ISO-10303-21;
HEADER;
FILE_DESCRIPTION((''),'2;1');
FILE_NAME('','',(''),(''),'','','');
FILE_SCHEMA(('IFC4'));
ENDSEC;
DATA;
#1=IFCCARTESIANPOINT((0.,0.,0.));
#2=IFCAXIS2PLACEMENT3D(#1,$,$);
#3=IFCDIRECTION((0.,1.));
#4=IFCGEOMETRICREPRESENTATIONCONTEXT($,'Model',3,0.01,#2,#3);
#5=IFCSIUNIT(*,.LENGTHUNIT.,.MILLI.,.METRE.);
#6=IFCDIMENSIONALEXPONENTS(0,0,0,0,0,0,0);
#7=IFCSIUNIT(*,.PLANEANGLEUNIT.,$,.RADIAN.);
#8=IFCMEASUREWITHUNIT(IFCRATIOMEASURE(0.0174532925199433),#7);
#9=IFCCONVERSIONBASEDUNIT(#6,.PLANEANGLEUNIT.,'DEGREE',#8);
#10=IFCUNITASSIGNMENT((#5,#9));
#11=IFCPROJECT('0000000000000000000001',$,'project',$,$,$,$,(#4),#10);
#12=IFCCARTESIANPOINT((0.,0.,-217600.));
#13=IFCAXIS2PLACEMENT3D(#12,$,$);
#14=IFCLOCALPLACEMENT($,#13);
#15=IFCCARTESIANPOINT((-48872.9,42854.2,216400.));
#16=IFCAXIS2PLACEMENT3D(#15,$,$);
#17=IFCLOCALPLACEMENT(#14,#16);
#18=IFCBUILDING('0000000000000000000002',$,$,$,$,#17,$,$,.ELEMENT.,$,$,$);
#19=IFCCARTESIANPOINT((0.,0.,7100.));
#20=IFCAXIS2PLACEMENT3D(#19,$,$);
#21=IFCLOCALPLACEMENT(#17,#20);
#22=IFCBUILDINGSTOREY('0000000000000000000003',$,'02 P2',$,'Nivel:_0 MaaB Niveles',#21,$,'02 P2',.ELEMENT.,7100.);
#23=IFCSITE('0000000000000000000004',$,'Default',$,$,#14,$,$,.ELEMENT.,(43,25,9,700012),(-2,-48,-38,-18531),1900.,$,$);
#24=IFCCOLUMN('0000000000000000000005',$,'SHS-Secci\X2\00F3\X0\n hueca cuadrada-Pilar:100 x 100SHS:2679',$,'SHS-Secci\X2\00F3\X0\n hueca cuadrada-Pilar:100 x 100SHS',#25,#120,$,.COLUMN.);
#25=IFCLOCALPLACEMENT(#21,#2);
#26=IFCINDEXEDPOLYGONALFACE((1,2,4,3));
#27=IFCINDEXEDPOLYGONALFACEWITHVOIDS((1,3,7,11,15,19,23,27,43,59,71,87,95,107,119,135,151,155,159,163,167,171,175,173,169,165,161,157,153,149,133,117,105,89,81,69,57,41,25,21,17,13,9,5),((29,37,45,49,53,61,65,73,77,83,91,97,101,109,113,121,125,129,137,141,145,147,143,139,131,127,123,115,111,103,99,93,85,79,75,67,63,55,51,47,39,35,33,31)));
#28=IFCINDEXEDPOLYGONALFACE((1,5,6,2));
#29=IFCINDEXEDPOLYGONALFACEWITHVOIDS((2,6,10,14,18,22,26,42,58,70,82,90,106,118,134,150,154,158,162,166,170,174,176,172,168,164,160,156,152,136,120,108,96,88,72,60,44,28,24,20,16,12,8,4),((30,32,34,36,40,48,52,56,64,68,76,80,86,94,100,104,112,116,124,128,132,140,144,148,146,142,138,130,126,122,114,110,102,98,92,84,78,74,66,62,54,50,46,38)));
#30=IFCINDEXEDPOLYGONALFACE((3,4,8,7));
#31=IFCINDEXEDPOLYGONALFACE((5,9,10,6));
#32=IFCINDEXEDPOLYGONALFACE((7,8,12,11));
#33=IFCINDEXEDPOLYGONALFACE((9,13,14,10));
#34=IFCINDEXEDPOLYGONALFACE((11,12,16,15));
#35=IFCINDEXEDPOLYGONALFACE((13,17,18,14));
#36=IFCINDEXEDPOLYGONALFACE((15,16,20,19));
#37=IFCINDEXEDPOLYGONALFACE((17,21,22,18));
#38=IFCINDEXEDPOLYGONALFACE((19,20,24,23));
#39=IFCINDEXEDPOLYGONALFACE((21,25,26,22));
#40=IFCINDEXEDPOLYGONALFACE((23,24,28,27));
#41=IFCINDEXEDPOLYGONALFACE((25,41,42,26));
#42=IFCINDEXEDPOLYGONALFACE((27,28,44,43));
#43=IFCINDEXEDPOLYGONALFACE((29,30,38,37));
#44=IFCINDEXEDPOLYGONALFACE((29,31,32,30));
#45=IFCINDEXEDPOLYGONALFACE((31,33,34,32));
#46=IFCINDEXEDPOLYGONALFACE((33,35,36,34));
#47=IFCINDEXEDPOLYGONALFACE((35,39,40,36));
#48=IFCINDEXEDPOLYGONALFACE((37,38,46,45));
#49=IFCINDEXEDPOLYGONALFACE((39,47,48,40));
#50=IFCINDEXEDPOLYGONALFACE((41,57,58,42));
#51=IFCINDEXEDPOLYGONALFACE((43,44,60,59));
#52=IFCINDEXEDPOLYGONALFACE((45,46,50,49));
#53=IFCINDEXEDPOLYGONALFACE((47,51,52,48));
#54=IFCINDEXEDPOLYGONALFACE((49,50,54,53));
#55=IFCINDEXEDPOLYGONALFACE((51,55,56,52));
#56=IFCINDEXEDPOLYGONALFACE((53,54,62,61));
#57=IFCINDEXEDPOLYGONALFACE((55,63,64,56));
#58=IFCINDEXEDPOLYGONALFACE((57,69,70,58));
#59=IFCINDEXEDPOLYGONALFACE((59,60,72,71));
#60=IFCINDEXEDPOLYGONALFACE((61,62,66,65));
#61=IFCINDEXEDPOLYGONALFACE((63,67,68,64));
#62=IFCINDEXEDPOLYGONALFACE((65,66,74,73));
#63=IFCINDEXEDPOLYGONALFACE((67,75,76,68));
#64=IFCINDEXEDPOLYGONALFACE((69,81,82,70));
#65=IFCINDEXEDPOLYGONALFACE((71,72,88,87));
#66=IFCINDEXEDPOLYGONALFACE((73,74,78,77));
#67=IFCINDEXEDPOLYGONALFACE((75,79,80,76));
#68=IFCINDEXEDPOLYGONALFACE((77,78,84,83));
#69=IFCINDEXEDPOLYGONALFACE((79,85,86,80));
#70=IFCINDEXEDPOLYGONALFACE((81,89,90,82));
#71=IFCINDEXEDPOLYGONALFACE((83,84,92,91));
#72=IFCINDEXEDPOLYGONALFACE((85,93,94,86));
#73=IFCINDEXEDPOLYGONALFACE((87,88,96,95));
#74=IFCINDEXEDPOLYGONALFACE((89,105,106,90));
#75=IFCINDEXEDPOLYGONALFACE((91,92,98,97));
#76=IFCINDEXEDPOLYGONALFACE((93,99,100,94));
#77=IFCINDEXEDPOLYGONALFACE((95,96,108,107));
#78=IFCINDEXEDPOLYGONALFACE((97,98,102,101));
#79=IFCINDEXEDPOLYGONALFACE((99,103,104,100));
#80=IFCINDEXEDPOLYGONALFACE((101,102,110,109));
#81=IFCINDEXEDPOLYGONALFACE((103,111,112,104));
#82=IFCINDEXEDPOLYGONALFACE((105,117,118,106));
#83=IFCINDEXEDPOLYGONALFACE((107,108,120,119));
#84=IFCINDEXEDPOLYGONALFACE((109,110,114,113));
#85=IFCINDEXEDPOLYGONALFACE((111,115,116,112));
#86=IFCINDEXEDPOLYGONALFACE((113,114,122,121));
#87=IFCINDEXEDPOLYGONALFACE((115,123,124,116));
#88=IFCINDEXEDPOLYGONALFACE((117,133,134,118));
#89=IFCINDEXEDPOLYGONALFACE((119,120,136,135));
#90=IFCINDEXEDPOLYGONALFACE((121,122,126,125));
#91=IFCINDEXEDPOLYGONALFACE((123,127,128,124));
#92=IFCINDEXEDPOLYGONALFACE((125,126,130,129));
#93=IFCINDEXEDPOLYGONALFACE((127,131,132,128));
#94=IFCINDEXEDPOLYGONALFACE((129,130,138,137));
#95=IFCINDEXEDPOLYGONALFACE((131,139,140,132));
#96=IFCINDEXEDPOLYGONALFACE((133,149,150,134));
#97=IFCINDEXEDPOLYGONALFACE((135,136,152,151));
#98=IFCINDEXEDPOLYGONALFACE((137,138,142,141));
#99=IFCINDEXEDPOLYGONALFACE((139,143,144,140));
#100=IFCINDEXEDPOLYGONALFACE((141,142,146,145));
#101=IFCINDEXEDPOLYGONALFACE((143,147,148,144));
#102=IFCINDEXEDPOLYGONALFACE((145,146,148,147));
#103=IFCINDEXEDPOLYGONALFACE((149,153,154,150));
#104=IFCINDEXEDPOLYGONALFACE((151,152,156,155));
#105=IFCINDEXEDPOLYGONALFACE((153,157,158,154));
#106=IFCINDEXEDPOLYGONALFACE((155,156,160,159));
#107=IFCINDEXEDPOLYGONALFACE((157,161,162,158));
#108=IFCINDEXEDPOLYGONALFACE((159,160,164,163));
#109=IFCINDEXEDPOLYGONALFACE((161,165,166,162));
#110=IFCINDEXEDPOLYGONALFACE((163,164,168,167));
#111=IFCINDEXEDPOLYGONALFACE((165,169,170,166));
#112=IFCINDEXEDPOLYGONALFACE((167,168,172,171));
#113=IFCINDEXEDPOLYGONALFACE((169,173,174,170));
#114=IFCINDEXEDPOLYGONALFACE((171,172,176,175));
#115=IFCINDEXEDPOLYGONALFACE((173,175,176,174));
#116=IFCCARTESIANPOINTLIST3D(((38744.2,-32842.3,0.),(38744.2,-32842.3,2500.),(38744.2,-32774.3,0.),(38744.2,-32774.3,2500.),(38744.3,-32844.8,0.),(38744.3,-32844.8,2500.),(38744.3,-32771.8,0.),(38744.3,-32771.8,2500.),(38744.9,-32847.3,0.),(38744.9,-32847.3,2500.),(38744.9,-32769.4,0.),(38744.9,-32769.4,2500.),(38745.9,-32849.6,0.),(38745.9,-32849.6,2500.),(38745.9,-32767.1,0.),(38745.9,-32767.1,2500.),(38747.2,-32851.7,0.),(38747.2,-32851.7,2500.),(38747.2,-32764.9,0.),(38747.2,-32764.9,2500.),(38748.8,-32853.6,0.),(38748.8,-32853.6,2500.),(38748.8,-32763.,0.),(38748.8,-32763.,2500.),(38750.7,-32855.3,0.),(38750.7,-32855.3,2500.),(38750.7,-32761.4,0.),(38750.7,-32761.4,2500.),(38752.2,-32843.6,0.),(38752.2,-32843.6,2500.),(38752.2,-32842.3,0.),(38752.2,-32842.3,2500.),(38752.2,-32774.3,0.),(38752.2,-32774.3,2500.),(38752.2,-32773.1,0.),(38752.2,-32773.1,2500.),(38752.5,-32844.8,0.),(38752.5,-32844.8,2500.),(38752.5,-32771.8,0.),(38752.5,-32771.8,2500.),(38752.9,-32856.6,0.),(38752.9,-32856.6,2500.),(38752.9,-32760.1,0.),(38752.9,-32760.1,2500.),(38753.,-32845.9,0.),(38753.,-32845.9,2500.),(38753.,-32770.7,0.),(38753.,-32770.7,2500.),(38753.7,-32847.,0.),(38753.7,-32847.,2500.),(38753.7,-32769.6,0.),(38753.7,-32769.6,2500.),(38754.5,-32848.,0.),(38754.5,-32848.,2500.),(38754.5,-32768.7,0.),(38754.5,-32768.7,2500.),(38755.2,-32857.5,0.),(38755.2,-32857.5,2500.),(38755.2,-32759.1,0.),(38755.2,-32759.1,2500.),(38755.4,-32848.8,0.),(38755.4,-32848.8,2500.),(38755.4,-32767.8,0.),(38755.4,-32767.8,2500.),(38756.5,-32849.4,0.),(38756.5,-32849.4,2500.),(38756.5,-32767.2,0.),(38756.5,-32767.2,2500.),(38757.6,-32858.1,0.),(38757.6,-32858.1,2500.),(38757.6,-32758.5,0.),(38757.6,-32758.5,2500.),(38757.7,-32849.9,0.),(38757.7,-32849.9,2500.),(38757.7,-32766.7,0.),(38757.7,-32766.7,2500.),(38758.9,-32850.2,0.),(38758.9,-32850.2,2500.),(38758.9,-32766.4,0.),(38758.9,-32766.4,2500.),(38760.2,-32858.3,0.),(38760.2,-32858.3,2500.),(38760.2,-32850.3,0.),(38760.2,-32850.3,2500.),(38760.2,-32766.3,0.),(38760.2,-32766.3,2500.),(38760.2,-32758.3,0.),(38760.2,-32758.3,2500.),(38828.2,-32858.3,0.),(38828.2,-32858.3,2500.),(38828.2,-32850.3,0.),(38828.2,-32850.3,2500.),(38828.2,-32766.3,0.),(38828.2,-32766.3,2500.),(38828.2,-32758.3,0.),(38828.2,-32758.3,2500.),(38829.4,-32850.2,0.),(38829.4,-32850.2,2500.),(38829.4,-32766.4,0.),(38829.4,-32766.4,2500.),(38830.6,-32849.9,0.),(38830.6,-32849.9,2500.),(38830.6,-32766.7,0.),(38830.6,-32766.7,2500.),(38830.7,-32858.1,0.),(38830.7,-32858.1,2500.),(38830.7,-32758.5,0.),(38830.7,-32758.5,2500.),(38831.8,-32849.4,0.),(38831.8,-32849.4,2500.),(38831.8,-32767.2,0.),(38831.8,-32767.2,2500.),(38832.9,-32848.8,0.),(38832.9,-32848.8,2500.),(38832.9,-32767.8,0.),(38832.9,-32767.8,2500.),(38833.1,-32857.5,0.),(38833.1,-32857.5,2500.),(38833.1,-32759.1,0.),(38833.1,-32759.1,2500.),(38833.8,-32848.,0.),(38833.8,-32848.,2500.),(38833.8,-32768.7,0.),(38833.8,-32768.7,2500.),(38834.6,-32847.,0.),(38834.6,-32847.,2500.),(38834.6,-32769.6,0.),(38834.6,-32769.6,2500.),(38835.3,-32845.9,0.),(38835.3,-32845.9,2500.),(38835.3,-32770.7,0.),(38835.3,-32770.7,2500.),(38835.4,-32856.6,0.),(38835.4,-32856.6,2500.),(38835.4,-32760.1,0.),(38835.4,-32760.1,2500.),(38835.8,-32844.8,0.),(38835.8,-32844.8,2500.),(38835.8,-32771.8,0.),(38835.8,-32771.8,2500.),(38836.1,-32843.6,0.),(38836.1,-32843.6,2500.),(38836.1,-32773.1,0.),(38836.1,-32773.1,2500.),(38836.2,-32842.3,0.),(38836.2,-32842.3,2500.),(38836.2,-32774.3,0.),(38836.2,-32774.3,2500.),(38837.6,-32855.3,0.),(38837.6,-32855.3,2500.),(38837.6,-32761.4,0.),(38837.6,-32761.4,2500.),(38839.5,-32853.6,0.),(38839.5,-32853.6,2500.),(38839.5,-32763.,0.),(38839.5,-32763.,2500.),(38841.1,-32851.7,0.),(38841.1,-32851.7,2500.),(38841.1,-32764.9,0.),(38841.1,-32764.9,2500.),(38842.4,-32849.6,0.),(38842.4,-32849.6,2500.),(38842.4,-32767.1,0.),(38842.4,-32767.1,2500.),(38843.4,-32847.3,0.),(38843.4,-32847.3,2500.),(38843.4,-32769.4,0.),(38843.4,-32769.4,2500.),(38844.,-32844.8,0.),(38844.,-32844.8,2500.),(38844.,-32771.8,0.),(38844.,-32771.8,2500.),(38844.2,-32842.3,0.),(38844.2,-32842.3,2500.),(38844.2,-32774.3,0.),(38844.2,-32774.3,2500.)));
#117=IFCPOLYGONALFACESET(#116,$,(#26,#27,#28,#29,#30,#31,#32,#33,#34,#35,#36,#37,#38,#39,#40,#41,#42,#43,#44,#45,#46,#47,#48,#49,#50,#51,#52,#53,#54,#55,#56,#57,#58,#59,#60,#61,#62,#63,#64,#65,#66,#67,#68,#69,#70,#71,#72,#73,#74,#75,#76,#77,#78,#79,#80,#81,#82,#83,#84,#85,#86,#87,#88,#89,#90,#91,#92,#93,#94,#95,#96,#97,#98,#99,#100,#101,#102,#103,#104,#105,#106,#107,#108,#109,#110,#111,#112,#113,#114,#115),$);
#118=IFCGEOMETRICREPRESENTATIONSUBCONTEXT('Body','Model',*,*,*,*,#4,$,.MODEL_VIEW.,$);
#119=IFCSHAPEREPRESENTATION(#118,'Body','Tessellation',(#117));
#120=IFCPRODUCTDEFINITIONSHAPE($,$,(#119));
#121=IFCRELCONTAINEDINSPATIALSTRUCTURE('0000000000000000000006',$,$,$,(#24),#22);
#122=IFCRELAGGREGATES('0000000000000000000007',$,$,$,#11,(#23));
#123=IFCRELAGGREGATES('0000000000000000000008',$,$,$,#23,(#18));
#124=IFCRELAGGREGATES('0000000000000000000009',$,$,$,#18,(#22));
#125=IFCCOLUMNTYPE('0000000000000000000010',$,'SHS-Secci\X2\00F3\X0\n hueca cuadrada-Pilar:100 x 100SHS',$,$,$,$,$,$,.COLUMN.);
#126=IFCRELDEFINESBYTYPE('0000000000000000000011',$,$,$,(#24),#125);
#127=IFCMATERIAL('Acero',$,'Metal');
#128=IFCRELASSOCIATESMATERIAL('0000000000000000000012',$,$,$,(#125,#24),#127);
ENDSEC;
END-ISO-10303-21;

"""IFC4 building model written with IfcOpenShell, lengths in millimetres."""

from ifc_helpers import new_model, entity, si_unit, converted_unit, direction, frame, origin, place, context, subcontext, project, spatial, indexed_curve, outline, extrude, source, transform, mapped, material, type_object, type_shapes, element, save


model = new_model("IFC4")

# Units and contexts
model_context = context("Model", 3, precision=0.01, world=origin(), true_north=direction((0.0, 1.0)))
body_context = subcontext(model_context, "Body", "Model", "MODEL_VIEW")
ifc_project = project(units=[si_unit("LENGTHUNIT", "METRE", prefix="MILLI"), converted_unit("PLANEANGLEUNIT", "DEGREE", entity("IfcRatioMeasure", 0.0174532925199433), si_unit("PLANEANGLEUNIT", "RADIAN"), dimensions=[0, 0, 0, 0, 0, 0, 0])], contexts=[model_context])

# Site, building, storey
site_placement = place(None, frame((0.0, 0.0, -217600.0)))
site = spatial("IfcSite", under=ifc_project, at=site_placement, Name="Default", CompositionType="ELEMENT", RefLatitude=(43, 25, 9, 700012), RefLongitude=(-2, -48, -38, -18531), RefElevation=1900.0)
building_placement = place(site_placement, frame((-48872.9, 42854.2, 216400.0)))
building = spatial("IfcBuilding", under=site, at=building_placement, CompositionType="ELEMENT")
storey_placement = place(building_placement, frame((0.0, 0.0, 7100.0)))
storey = spatial("IfcBuildingStorey", under=building, at=storey_placement, Name="02 P2", ObjectType="Nivel:_0 MaaB Niveles", LongName="02 P2", CompositionType="ELEMENT", Elevation=7100.0)

# Column
ifc_material_1 = material(Name="Acero", Category="Metal")
column_type_1 = type_object("IfcColumnType", Name="SHS-Sección hueca cuadrada-Pilar:100 x 100SHS", PredefinedType="COLUMN", material=ifc_material_1)
shared_shape_1 = source(origin(), body_context, "Body", "SweptSolid", [
    extrude(outline(indexed_curve([(-34.0, -50.0), (34.0, -50.0), (36.5, -49.8), (38.9, -49.2), (41.3, -48.3), (43.4, -46.9), (45.3, -45.3), (46.9, -43.4), (48.3, -41.3), (49.2, -38.9), (49.8, -36.5), (50.0, -34.0), (50.0, 34.0), (49.8, 36.5), (49.2, 38.9), (48.3, 41.3), (46.9, 43.4), (45.3, 45.3), (43.4, 46.9), (41.3, 48.3), (38.9, 49.2), (36.5, 49.8), (34.0, 50.0), (-34.0, 50.0), (-36.5, 49.8), (-38.9, 49.2), (-41.3, 48.3), (-43.4, 46.9), (-45.3, 45.3), (-46.9, 43.4), (-48.3, 41.3), (-49.2, 38.9), (-49.8, 36.5), (-50.0, 34.0), (-50.0, -34.0), (-49.8, -36.5), (-49.2, -38.9), (-48.3, -41.3), (-46.9, -43.4), (-45.3, -45.3), (-43.4, -46.9), (-41.3, -48.3), (-38.9, -49.2), (-36.5, -49.8), (-34.0, -50.0)], self_intersect=False), holes=[indexed_curve([(-42.0, 34.0), (-41.9, 35.3), (-41.6, 36.5), (-41.1, 37.6), (-40.5, 38.7), (-39.7, 39.7), (-38.7, 40.5), (-37.6, 41.1), (-36.5, 41.6), (-35.3, 41.9), (-34.0, 42.0), (34.0, 42.0), (35.3, 41.9), (36.5, 41.6), (37.6, 41.1), (38.7, 40.5), (39.7, 39.7), (40.5, 38.7), (41.1, 37.6), (41.6, 36.5), (41.9, 35.3), (42.0, 34.0), (42.0, -34.0), (41.9, -35.3), (41.6, -36.5), (41.1, -37.6), (40.5, -38.7), (39.7, -39.7), (38.7, -40.5), (37.6, -41.1), (36.5, -41.6), (35.3, -41.9), (34.0, -42.0), (-34.0, -42.0), (-35.3, -41.9), (-36.5, -41.6), (-37.6, -41.1), (-38.7, -40.5), (-39.7, -39.7), (-40.5, -38.7), (-41.1, -37.6), (-41.6, -36.5), (-41.9, -35.3), (-42.0, -34.0), (-42.0, 34.0)], self_intersect=False)]), frame((0.0, 0.0, 7100.0), z_axis=(0.0, 0.0, 1.0), x_axis=(0.0, 1.0, 0.0)), (0.0, 0.0, 1.0), 2500.0),
])
type_shapes(column_type_1, [shared_shape_1])
column_1_placement = place(storey_placement, frame((38794.2, -32808.3, -7100.0), z_axis=(0.0, 0.0, 1.0), x_axis=(0.0, -1.0, 0.0)))
element("IfcColumn", 1, at=column_1_placement, inside=storey, type_object=column_type_1, material=ifc_material_1, Name="SHS-Sección hueca cuadrada-Pilar:100 x 100SHS:2679", ObjectType="SHS-Sección hueca cuadrada-Pilar:100 x 100SHS", PredefinedType="COLUMN", context=body_context, shape_type="MappedRepresentation", body=[
    mapped(shared_shape_1, transform((0.0, 0.0, 0.0), scale=1.0)),
])

save(model, "model.ifc")
